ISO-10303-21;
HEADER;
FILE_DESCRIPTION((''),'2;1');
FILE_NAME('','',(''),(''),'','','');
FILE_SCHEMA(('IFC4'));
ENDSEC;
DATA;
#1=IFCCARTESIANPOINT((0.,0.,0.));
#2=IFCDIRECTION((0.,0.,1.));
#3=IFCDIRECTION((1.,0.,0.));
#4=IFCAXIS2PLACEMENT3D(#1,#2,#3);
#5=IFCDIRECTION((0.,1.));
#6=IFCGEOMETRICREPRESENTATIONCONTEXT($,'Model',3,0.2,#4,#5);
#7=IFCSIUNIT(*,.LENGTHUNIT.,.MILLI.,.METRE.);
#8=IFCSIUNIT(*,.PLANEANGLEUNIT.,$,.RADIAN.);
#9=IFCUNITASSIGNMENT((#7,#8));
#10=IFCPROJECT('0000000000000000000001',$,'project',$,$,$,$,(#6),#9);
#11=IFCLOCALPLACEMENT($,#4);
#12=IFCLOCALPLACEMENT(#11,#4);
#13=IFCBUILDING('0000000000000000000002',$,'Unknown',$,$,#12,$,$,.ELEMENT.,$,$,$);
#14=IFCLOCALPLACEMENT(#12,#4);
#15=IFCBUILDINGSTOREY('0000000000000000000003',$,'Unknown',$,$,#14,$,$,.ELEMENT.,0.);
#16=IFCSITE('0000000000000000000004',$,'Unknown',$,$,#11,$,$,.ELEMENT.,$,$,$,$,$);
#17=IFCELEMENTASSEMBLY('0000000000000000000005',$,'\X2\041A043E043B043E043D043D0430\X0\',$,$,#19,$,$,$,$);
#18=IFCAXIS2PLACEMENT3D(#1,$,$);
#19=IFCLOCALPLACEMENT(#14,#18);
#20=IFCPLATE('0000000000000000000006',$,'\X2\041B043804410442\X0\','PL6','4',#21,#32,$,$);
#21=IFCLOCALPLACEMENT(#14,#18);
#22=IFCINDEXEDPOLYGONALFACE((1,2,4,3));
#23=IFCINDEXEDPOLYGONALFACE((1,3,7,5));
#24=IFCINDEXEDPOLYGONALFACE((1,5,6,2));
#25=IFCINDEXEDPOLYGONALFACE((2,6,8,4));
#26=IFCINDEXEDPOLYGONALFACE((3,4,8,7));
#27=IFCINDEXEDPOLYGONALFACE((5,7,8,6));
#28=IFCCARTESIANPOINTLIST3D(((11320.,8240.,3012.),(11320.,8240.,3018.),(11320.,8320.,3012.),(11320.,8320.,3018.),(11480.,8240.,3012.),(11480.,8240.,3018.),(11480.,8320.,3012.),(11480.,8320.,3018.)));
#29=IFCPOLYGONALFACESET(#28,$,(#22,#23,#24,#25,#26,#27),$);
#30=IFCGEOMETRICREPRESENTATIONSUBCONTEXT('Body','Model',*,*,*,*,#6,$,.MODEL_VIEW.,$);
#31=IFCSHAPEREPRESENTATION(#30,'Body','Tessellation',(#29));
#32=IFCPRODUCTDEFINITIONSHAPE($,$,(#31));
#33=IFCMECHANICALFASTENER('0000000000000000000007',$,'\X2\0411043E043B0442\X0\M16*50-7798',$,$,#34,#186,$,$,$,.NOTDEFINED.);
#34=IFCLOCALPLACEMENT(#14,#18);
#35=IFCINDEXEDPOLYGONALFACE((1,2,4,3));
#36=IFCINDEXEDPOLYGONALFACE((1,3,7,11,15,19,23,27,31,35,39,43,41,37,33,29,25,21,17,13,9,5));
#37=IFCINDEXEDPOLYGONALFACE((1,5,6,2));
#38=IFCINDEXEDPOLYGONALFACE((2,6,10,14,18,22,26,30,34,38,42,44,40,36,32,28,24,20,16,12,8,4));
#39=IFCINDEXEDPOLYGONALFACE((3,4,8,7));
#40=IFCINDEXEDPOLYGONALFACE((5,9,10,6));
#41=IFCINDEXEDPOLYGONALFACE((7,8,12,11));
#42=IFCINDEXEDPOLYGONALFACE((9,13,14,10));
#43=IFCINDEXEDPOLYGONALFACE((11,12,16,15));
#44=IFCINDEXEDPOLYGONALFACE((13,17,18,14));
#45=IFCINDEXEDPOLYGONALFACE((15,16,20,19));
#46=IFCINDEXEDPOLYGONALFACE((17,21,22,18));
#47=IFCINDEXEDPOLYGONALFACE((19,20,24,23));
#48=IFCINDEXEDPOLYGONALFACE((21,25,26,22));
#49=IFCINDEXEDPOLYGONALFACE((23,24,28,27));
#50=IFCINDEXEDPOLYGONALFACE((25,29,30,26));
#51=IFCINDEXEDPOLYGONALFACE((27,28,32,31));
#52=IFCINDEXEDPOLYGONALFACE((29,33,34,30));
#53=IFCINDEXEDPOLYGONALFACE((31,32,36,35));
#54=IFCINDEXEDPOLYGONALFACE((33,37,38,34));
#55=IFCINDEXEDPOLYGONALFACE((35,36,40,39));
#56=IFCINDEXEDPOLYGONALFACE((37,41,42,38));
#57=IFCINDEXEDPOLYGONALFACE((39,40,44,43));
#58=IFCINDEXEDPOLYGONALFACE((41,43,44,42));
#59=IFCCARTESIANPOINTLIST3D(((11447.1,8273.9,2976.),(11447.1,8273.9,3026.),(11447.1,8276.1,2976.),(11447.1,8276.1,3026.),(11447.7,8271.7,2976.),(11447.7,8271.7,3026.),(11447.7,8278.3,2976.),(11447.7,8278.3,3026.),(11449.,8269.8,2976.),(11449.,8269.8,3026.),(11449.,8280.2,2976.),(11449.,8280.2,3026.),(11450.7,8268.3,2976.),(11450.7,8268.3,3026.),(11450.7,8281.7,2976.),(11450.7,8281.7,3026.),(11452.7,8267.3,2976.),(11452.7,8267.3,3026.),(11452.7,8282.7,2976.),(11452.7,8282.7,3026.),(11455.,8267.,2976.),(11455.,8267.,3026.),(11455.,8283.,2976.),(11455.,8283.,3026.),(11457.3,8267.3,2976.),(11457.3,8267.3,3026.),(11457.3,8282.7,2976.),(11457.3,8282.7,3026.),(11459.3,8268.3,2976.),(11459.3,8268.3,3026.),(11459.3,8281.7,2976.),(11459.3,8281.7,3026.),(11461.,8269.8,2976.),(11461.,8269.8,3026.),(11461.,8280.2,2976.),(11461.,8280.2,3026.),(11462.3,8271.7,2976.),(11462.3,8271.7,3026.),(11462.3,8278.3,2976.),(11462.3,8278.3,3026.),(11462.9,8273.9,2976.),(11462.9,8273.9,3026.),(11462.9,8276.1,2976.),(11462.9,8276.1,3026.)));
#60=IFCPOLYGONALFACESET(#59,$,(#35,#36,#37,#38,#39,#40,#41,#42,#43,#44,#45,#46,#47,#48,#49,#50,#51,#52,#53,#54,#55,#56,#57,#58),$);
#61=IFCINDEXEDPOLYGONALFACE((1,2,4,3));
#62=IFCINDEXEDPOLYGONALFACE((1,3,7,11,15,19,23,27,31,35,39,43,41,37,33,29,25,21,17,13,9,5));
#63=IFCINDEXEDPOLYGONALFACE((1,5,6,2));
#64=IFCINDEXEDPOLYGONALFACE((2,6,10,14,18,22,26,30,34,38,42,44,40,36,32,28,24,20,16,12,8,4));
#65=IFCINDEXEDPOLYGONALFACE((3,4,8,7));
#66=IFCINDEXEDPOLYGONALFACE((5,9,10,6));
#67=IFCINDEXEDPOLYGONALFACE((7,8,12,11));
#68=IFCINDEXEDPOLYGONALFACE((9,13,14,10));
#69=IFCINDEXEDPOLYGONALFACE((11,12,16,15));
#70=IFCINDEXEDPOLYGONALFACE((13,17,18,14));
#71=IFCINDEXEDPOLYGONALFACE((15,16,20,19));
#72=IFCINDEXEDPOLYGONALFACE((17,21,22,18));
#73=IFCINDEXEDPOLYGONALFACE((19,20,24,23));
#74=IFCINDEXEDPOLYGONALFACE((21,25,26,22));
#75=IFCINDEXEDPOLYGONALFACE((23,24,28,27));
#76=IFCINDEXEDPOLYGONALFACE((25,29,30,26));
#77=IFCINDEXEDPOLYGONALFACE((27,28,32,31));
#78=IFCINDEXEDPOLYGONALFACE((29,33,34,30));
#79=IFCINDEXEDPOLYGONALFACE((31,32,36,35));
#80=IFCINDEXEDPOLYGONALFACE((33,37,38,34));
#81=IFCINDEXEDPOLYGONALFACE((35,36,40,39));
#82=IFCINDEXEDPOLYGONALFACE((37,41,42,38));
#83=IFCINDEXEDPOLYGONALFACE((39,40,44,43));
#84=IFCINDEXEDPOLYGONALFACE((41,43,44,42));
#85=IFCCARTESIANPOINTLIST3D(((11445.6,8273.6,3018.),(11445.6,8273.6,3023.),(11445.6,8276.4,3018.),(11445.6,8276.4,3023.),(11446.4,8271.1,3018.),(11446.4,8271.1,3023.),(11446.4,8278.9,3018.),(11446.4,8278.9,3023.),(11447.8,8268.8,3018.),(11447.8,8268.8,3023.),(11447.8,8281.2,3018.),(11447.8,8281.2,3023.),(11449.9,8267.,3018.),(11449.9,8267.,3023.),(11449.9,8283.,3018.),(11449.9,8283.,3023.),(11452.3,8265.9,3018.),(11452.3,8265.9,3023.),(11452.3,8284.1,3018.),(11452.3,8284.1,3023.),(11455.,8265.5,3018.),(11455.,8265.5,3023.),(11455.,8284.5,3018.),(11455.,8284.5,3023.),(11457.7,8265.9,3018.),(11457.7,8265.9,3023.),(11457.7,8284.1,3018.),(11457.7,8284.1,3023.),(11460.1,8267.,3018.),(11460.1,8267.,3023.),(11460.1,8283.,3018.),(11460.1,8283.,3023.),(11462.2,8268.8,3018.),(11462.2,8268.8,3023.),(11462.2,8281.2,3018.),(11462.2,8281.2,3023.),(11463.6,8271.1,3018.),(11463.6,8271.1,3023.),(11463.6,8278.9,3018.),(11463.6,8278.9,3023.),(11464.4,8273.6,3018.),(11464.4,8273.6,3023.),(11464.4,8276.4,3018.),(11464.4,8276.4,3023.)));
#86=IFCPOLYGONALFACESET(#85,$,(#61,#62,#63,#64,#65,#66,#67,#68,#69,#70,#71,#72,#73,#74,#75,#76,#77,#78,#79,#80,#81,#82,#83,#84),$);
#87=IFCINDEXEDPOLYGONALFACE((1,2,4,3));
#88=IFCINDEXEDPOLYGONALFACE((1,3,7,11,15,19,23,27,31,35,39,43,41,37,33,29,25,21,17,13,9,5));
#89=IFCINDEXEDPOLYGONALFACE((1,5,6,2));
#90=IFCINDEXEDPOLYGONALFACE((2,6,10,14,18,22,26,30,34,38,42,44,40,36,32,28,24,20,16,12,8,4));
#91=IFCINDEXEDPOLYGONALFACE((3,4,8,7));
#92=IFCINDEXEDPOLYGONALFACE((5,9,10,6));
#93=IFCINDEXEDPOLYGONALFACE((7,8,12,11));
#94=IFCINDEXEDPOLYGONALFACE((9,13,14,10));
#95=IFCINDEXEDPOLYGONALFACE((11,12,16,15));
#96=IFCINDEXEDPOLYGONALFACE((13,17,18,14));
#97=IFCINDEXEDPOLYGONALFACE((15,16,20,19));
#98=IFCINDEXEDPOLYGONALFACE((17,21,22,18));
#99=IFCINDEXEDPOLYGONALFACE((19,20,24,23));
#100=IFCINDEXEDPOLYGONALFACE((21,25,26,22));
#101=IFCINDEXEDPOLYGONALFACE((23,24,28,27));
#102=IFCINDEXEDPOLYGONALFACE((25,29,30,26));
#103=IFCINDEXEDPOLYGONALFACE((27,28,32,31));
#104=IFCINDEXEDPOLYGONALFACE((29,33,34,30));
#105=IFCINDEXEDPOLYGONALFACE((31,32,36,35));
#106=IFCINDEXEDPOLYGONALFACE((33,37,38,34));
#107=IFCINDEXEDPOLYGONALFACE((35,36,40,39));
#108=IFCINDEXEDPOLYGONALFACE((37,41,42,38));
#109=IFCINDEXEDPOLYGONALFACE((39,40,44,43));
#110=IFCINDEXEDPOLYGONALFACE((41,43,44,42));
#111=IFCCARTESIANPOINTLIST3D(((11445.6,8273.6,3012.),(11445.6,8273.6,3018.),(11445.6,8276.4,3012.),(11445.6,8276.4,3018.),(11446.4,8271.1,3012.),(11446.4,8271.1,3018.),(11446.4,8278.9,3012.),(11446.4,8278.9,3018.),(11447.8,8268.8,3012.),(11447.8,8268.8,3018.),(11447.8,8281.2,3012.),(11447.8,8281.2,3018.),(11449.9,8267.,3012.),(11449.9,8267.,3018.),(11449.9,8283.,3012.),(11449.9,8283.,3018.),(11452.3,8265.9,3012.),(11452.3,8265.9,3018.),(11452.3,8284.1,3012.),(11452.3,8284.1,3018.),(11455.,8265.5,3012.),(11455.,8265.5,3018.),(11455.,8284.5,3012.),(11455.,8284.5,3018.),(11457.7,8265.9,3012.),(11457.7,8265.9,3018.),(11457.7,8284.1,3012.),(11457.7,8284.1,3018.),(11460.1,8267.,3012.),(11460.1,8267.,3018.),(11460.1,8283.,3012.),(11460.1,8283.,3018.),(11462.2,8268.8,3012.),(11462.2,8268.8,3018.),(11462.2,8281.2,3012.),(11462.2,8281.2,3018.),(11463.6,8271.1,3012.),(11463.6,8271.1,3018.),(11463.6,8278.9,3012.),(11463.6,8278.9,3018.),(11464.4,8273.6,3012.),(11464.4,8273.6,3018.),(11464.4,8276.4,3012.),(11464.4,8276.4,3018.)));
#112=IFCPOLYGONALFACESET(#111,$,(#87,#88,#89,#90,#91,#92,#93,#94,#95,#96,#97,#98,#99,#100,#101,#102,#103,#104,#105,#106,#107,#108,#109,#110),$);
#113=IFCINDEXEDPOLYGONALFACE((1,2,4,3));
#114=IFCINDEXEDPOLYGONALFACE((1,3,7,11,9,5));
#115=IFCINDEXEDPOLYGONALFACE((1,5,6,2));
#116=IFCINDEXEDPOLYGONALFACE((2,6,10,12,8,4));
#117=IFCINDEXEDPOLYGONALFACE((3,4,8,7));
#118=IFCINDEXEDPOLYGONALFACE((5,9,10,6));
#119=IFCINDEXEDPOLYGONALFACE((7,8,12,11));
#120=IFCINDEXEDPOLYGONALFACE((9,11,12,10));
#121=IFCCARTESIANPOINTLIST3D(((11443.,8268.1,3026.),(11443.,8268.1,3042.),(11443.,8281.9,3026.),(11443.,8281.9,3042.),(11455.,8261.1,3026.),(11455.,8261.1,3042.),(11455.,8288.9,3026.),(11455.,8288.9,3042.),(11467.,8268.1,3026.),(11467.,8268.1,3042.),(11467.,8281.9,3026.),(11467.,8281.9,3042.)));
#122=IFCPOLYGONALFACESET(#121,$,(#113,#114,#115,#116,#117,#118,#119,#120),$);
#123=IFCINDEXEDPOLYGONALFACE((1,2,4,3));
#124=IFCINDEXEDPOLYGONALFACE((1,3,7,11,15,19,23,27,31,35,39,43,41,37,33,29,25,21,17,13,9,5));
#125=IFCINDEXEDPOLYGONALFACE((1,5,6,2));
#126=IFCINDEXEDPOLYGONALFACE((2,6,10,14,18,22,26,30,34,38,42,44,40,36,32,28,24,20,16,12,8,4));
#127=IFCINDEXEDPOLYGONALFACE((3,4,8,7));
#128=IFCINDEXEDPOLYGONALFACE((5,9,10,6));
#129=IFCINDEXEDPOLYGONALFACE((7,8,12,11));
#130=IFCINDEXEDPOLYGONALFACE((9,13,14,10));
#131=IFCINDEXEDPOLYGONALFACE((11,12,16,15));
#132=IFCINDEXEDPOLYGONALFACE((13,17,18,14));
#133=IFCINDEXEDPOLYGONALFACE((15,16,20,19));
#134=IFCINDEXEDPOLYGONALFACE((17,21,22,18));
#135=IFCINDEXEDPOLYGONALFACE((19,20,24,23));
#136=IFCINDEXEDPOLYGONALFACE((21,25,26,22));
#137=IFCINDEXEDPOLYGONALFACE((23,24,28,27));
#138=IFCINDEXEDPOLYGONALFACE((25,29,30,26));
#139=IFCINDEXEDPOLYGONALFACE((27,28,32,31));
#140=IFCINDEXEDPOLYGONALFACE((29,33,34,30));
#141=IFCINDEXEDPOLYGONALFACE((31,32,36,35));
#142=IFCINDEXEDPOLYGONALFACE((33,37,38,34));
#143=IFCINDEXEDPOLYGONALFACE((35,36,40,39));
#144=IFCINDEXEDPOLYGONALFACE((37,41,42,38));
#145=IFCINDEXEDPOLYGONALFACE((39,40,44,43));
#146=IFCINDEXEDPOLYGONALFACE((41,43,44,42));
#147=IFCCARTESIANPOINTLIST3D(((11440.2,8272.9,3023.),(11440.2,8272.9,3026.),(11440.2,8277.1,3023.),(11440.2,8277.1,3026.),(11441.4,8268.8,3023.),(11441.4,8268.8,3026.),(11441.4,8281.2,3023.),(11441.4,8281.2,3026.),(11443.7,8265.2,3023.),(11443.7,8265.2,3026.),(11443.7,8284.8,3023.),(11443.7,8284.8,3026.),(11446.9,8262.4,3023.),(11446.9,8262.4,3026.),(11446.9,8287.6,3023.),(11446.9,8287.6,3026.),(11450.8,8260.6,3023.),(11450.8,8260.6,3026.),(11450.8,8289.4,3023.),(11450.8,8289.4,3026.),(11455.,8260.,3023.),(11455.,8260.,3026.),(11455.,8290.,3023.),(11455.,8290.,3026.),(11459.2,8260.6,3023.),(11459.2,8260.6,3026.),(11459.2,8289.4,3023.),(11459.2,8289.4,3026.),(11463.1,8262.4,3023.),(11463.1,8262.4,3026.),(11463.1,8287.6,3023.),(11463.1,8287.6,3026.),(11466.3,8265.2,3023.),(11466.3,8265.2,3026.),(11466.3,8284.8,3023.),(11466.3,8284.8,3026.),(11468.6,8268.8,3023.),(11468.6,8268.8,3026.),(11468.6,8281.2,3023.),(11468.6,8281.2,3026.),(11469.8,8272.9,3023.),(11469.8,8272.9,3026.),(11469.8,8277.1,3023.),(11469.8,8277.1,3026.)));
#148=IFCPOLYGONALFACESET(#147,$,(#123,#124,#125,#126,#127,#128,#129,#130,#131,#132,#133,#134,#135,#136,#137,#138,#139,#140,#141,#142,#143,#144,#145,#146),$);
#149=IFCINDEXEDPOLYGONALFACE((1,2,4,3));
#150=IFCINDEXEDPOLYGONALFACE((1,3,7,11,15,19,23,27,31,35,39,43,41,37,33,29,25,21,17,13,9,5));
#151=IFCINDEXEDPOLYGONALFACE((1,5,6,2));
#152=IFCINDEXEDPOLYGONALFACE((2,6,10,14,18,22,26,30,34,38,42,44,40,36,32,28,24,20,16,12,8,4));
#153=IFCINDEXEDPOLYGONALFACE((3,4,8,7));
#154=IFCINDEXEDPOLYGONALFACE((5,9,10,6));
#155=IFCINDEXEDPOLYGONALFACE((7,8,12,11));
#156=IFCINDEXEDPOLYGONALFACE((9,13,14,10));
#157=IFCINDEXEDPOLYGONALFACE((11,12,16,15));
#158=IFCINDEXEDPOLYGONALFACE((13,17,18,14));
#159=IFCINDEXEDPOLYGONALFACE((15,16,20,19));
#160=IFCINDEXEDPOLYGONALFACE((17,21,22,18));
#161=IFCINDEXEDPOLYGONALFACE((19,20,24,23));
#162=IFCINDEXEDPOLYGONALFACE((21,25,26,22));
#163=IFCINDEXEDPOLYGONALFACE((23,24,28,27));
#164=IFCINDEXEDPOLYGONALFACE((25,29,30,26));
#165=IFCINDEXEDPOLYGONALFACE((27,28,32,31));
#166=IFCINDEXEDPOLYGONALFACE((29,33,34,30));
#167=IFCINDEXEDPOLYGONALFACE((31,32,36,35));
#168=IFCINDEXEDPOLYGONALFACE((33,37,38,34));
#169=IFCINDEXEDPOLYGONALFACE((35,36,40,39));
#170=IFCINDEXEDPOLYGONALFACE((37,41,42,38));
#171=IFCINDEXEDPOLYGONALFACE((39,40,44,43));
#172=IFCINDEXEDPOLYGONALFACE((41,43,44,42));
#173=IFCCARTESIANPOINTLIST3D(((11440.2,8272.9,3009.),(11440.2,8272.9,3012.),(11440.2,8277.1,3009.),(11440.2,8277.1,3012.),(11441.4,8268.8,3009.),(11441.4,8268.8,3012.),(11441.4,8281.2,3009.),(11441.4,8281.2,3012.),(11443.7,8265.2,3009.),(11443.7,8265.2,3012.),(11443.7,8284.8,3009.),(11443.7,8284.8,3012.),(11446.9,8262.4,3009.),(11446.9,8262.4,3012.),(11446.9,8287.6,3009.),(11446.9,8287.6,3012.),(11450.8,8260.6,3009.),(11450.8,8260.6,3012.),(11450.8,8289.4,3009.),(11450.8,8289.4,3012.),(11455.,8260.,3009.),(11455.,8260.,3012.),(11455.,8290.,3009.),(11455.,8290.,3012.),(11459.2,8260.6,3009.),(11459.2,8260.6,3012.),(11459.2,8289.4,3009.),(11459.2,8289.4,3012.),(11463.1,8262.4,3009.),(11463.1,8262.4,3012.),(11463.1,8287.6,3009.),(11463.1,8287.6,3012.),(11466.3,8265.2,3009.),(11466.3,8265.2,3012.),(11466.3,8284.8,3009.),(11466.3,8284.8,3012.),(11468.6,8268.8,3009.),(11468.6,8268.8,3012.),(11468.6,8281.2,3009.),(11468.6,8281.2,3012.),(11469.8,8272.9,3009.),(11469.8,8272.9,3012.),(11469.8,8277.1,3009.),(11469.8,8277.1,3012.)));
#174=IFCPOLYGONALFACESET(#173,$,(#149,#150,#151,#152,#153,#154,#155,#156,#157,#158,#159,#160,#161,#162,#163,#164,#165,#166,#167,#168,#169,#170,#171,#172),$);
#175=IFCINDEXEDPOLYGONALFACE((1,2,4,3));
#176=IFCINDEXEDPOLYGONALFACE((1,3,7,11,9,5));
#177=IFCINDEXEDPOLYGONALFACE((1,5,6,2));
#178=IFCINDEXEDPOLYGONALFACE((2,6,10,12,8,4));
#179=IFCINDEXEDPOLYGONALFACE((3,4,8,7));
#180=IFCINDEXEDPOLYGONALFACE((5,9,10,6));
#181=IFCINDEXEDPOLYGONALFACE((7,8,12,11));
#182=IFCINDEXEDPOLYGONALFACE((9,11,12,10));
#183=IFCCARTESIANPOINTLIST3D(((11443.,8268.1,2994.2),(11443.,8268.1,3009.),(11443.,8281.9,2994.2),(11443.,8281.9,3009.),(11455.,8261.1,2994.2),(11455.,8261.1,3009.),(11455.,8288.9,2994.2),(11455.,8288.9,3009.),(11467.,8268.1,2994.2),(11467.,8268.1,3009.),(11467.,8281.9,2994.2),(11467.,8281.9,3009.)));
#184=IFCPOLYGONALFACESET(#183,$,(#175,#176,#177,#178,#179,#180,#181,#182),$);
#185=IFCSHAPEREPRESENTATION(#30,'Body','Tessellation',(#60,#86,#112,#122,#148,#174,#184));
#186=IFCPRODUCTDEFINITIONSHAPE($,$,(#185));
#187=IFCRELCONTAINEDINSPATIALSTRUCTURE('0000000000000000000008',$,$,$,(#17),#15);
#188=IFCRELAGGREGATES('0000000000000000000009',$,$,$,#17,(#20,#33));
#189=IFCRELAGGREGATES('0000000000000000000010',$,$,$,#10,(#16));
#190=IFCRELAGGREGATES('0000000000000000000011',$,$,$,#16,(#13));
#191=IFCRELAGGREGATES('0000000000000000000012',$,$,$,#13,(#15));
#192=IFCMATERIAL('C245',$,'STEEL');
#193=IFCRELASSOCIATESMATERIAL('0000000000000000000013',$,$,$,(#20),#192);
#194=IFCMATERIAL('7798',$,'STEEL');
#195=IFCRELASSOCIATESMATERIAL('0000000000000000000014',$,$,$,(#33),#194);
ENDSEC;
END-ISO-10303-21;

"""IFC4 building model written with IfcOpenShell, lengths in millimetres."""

from ifc_helpers import new_model, si_unit, direction, frame, origin_with_axes, place, context, subcontext, project, spatial, line, arc, indexed_curve, outline, extrude, source, transform, mapped, material, element, aggregate, save


model = new_model("IFC4")

# Units and contexts
model_context = context("Model", 3, precision=0.2, world=origin_with_axes(), true_north=direction((0.0, 1.0)))
body_context = subcontext(model_context, "Body", "Model", "MODEL_VIEW")
ifc_project = project(units=[si_unit("LENGTHUNIT", "METRE", prefix="MILLI"), si_unit("PLANEANGLEUNIT", "RADIAN")], contexts=[model_context])

# Site, building, storey
site_placement = place(None, origin_with_axes())
site = spatial("IfcSite", under=ifc_project, at=site_placement, Name="Unknown", CompositionType="ELEMENT")
building_placement = place(site_placement, origin_with_axes())
building = spatial("IfcBuilding", under=site, at=building_placement, Name="Unknown", CompositionType="ELEMENT")
storey_placement = place(building_placement, origin_with_axes())
storey = spatial("IfcBuildingStorey", under=building, at=storey_placement, Name="Unknown", CompositionType="ELEMENT", Elevation=0.0)

# Shared definitions
ifc_material_1 = material(Name="C245", Category="STEEL")

# Element assembly
assembly_1_placement = place(storey_placement, frame((11400.0, 8400.0, -40.0), z_axis=(-1.0, 0.0, 0.0), x_axis=(0.0, 0.0, 1.0)))
assembly_1 = element("IfcElementAssembly", 1, at=assembly_1_placement, inside=storey, Name="Колонна")

# Plate
plate_1_placement = place(assembly_1_placement, frame((3055.0, -80.0, -80.0), z_axis=(1.0, 0.0, 0.0), x_axis=(0.0, 0.0, 1.0)))
plate_1 = element("IfcPlate", 2, at=plate_1_placement, material=ifc_material_1, Name="Лист", Description="PL6", ObjectType="4", context=body_context, shape_type="SolidModel", body=[
    extrude(outline(indexed_curve([(0.0, 0.0), (160.0, 0.0), (160.0, 80.0), (0.0, 80.0)], segments=[line(1, 2, 3, 4, 1)])), frame((0.0, 0.0, 3.0), z_axis=(0.0, 0.0, 1.0), x_axis=(1.0, 0.0, 0.0)), (0.0, 0.0, -1.0), 6.0),
])

# Mechanical fastener
ifc_material_2 = material(Name="7798", Category="STEEL")
shared_shape_1 = source(origin_with_axes(), body_context, "Body", "SweptSolid", [
    extrude(outline(indexed_curve([(8.0, 0.0), (0.0, 8.0), (-8.0, 0.0), (0.0, -8.0)], segments=[arc(1, 2, 3), arc(3, 4, 1)])), frame((0.0, 0.0, 8.0), z_axis=(0.0, 0.0, -1.0), x_axis=(0.0, 1.0, 0.0)), (0.0, 0.0, 1.0), 50.0),
    extrude(outline(indexed_curve([(9.5, 0.0), (0.0, 9.5), (-9.5, 0.0), (0.0, -9.5)], segments=[arc(1, 2, 3), arc(3, 4, 1)])), frame((0.0, 0.0, 5.0), z_axis=(0.0, 0.0, -1.0), x_axis=(0.0, 1.0, 0.0)), (0.0, 0.0, 1.0), 5.0),
    extrude(outline(indexed_curve([(9.5, 0.0), (0.0, 9.5), (-9.5, 0.0), (0.0, -9.5)], segments=[arc(1, 2, 3), arc(3, 4, 1)])), frame((0.0, 0.0, 0.0), z_axis=(0.0, 0.0, -1.0), x_axis=(0.0, 1.0, 0.0)), (0.0, 0.0, 1.0), 6.0),
    extrude(outline(indexed_curve([(13.9, 0.0), (6.9, 12.0), (-6.9, 12.0), (-13.9, 0.0), (-6.9, -12.0), (6.9, -12.0)], segments=[line(1, 2, 3, 4, 5, 6, 1)])), frame((0.0, 0.0, 24.0), z_axis=(0.0, 0.0, -1.0), x_axis=(0.0, 1.0, 0.0)), (0.0, 0.0, 1.0), 16.0),
    extrude(outline(indexed_curve([(15.0, 0.0), (0.0, 15.0), (-15.0, 0.0), (0.0, -15.0)], segments=[arc(1, 2, 3), arc(3, 4, 1)])), frame((0.0, 0.0, 8.0), z_axis=(0.0, 0.0, -1.0), x_axis=(0.0, 1.0, 0.0)), (0.0, 0.0, 1.0), 3.0),
    extrude(outline(indexed_curve([(15.0, 0.0), (0.0, 15.0), (-15.0, 0.0), (0.0, -15.0)], segments=[arc(1, 2, 3), arc(3, 4, 1)])), frame((0.0, 0.0, -6.0), z_axis=(0.0, 0.0, -1.0), x_axis=(0.0, 1.0, 0.0)), (0.0, 0.0, 1.0), 3.0),
    extrude(outline(indexed_curve([(13.9, 0.0), (6.9, 12.0), (-6.9, 12.0), (-13.9, 0.0), (-6.9, -12.0), (6.9, -12.0)], segments=[line(1, 2, 3, 4, 5, 6, 1)])), frame((0.0, 0.0, -9.0), z_axis=(0.0, 0.0, -1.0), x_axis=(0.0, 1.0, 0.0)), (0.0, 0.0, 1.0), 14.8),
])
mechanical_fastener_1_placement = place(assembly_1_placement, frame((3058.0, -125.0, -55.0), z_axis=(1.0, 0.0, 0.0), x_axis=(0.0, 0.0, 1.0)))
mechanical_fastener_1 = element("IfcMechanicalFastener", 3, at=mechanical_fastener_1_placement, material=ifc_material_2, Name="БолтM16*50-7798", PredefinedType="NOTDEFINED", context=body_context, shape_type="MappedRepresentation", body=[
    mapped(shared_shape_1, transform((0.0, 0.0, 0.0))),
])
aggregate(assembly_1, [plate_1, mechanical_fastener_1])

save(model, "model.ifc")
